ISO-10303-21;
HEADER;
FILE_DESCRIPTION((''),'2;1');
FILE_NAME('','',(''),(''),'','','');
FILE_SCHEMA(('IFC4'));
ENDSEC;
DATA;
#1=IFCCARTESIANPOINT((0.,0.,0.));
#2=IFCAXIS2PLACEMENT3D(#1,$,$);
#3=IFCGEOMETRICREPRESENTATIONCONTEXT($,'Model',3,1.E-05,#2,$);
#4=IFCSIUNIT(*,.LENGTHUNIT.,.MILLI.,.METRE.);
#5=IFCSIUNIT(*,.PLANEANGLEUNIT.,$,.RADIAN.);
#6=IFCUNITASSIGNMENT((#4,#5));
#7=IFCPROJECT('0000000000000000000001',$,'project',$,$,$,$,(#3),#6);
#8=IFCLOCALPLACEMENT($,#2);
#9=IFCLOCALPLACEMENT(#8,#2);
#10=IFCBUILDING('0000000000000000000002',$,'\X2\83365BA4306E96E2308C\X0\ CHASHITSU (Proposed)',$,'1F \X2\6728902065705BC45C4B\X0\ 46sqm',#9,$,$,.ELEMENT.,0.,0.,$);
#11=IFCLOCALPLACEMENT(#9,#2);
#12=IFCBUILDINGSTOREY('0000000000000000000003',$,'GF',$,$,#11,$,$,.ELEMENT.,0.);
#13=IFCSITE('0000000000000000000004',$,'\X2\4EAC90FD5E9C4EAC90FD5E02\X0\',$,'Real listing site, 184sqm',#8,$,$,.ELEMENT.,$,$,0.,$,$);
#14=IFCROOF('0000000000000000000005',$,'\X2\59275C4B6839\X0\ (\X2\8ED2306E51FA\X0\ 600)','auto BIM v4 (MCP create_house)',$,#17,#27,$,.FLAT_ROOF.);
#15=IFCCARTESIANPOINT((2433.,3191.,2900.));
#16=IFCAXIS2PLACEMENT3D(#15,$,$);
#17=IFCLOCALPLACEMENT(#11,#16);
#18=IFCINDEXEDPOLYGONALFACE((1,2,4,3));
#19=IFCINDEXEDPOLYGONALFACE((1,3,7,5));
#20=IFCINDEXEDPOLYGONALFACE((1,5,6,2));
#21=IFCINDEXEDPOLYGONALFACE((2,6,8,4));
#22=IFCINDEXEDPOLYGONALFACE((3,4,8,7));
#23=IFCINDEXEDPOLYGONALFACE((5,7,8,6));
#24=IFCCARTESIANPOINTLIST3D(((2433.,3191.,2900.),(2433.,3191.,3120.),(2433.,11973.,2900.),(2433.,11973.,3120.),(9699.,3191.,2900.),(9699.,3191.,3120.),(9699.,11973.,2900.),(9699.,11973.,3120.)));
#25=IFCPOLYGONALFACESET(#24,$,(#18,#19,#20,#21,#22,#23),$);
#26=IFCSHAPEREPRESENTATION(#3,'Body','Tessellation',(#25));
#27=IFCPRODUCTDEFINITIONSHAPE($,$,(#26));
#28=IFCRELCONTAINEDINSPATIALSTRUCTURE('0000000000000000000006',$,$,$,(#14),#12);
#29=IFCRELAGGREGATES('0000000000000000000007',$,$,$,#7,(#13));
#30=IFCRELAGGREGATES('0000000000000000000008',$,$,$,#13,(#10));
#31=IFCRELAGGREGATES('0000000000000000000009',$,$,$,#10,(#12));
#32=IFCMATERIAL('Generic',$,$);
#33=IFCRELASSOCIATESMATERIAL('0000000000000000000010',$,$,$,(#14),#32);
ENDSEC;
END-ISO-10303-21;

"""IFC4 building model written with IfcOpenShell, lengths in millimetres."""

from ifc_helpers import new_model, si_unit, frame, frame_2d, origin, place, context, project, spatial, rectangle, extrude, material, element, save


model = new_model("IFC4")

# Units and contexts
model_context = context("Model", 3, precision=1e-05, world=origin())
ifc_project = project(units=[si_unit("LENGTHUNIT", "METRE", prefix="MILLI"), si_unit("PLANEANGLEUNIT", "RADIAN")], contexts=[model_context])

# Site, building, storey
site_placement = place(None, origin())
site = spatial("IfcSite", under=ifc_project, at=site_placement, Name="京都府京都市", ObjectType="Real listing site, 184sqm", CompositionType="ELEMENT", RefElevation=0.0)
building_placement = place(site_placement, origin())
building = spatial("IfcBuilding", under=site, at=building_placement, Name="茶室の離れ CHASHITSU (Proposed)", ObjectType="1F 木造数寄屋 46sqm", CompositionType="ELEMENT", ElevationOfRefHeight=0.0, ElevationOfTerrain=0.0)
storey_placement = place(building_placement, origin())
storey = spatial("IfcBuildingStorey", under=building, at=storey_placement, Name="GF", CompositionType="ELEMENT", Elevation=0.0)

# Shared definitions
ifc_material = material(Name="Generic")

# Roof
roof_placement = place(storey_placement, frame((2433.0, 3191.0, 2900.0)))
element("IfcRoof", 1, at=roof_placement, inside=storey, material=ifc_material, Name="大屋根 (軒の出 600)", Description="auto BIM v4 (MCP create_house)", PredefinedType="FLAT_ROOF", context=model_context, shape_type="SweptSolid", body=[
    extrude(rectangle(XDim=7266.0, YDim=8782.0, at=frame_2d((3633.0, 4391.0))), frame((2433.0, 3191.0, 2900.0)), (0.0, 0.0, 1.0), 220.0),
])

save(model, "model.ifc")
